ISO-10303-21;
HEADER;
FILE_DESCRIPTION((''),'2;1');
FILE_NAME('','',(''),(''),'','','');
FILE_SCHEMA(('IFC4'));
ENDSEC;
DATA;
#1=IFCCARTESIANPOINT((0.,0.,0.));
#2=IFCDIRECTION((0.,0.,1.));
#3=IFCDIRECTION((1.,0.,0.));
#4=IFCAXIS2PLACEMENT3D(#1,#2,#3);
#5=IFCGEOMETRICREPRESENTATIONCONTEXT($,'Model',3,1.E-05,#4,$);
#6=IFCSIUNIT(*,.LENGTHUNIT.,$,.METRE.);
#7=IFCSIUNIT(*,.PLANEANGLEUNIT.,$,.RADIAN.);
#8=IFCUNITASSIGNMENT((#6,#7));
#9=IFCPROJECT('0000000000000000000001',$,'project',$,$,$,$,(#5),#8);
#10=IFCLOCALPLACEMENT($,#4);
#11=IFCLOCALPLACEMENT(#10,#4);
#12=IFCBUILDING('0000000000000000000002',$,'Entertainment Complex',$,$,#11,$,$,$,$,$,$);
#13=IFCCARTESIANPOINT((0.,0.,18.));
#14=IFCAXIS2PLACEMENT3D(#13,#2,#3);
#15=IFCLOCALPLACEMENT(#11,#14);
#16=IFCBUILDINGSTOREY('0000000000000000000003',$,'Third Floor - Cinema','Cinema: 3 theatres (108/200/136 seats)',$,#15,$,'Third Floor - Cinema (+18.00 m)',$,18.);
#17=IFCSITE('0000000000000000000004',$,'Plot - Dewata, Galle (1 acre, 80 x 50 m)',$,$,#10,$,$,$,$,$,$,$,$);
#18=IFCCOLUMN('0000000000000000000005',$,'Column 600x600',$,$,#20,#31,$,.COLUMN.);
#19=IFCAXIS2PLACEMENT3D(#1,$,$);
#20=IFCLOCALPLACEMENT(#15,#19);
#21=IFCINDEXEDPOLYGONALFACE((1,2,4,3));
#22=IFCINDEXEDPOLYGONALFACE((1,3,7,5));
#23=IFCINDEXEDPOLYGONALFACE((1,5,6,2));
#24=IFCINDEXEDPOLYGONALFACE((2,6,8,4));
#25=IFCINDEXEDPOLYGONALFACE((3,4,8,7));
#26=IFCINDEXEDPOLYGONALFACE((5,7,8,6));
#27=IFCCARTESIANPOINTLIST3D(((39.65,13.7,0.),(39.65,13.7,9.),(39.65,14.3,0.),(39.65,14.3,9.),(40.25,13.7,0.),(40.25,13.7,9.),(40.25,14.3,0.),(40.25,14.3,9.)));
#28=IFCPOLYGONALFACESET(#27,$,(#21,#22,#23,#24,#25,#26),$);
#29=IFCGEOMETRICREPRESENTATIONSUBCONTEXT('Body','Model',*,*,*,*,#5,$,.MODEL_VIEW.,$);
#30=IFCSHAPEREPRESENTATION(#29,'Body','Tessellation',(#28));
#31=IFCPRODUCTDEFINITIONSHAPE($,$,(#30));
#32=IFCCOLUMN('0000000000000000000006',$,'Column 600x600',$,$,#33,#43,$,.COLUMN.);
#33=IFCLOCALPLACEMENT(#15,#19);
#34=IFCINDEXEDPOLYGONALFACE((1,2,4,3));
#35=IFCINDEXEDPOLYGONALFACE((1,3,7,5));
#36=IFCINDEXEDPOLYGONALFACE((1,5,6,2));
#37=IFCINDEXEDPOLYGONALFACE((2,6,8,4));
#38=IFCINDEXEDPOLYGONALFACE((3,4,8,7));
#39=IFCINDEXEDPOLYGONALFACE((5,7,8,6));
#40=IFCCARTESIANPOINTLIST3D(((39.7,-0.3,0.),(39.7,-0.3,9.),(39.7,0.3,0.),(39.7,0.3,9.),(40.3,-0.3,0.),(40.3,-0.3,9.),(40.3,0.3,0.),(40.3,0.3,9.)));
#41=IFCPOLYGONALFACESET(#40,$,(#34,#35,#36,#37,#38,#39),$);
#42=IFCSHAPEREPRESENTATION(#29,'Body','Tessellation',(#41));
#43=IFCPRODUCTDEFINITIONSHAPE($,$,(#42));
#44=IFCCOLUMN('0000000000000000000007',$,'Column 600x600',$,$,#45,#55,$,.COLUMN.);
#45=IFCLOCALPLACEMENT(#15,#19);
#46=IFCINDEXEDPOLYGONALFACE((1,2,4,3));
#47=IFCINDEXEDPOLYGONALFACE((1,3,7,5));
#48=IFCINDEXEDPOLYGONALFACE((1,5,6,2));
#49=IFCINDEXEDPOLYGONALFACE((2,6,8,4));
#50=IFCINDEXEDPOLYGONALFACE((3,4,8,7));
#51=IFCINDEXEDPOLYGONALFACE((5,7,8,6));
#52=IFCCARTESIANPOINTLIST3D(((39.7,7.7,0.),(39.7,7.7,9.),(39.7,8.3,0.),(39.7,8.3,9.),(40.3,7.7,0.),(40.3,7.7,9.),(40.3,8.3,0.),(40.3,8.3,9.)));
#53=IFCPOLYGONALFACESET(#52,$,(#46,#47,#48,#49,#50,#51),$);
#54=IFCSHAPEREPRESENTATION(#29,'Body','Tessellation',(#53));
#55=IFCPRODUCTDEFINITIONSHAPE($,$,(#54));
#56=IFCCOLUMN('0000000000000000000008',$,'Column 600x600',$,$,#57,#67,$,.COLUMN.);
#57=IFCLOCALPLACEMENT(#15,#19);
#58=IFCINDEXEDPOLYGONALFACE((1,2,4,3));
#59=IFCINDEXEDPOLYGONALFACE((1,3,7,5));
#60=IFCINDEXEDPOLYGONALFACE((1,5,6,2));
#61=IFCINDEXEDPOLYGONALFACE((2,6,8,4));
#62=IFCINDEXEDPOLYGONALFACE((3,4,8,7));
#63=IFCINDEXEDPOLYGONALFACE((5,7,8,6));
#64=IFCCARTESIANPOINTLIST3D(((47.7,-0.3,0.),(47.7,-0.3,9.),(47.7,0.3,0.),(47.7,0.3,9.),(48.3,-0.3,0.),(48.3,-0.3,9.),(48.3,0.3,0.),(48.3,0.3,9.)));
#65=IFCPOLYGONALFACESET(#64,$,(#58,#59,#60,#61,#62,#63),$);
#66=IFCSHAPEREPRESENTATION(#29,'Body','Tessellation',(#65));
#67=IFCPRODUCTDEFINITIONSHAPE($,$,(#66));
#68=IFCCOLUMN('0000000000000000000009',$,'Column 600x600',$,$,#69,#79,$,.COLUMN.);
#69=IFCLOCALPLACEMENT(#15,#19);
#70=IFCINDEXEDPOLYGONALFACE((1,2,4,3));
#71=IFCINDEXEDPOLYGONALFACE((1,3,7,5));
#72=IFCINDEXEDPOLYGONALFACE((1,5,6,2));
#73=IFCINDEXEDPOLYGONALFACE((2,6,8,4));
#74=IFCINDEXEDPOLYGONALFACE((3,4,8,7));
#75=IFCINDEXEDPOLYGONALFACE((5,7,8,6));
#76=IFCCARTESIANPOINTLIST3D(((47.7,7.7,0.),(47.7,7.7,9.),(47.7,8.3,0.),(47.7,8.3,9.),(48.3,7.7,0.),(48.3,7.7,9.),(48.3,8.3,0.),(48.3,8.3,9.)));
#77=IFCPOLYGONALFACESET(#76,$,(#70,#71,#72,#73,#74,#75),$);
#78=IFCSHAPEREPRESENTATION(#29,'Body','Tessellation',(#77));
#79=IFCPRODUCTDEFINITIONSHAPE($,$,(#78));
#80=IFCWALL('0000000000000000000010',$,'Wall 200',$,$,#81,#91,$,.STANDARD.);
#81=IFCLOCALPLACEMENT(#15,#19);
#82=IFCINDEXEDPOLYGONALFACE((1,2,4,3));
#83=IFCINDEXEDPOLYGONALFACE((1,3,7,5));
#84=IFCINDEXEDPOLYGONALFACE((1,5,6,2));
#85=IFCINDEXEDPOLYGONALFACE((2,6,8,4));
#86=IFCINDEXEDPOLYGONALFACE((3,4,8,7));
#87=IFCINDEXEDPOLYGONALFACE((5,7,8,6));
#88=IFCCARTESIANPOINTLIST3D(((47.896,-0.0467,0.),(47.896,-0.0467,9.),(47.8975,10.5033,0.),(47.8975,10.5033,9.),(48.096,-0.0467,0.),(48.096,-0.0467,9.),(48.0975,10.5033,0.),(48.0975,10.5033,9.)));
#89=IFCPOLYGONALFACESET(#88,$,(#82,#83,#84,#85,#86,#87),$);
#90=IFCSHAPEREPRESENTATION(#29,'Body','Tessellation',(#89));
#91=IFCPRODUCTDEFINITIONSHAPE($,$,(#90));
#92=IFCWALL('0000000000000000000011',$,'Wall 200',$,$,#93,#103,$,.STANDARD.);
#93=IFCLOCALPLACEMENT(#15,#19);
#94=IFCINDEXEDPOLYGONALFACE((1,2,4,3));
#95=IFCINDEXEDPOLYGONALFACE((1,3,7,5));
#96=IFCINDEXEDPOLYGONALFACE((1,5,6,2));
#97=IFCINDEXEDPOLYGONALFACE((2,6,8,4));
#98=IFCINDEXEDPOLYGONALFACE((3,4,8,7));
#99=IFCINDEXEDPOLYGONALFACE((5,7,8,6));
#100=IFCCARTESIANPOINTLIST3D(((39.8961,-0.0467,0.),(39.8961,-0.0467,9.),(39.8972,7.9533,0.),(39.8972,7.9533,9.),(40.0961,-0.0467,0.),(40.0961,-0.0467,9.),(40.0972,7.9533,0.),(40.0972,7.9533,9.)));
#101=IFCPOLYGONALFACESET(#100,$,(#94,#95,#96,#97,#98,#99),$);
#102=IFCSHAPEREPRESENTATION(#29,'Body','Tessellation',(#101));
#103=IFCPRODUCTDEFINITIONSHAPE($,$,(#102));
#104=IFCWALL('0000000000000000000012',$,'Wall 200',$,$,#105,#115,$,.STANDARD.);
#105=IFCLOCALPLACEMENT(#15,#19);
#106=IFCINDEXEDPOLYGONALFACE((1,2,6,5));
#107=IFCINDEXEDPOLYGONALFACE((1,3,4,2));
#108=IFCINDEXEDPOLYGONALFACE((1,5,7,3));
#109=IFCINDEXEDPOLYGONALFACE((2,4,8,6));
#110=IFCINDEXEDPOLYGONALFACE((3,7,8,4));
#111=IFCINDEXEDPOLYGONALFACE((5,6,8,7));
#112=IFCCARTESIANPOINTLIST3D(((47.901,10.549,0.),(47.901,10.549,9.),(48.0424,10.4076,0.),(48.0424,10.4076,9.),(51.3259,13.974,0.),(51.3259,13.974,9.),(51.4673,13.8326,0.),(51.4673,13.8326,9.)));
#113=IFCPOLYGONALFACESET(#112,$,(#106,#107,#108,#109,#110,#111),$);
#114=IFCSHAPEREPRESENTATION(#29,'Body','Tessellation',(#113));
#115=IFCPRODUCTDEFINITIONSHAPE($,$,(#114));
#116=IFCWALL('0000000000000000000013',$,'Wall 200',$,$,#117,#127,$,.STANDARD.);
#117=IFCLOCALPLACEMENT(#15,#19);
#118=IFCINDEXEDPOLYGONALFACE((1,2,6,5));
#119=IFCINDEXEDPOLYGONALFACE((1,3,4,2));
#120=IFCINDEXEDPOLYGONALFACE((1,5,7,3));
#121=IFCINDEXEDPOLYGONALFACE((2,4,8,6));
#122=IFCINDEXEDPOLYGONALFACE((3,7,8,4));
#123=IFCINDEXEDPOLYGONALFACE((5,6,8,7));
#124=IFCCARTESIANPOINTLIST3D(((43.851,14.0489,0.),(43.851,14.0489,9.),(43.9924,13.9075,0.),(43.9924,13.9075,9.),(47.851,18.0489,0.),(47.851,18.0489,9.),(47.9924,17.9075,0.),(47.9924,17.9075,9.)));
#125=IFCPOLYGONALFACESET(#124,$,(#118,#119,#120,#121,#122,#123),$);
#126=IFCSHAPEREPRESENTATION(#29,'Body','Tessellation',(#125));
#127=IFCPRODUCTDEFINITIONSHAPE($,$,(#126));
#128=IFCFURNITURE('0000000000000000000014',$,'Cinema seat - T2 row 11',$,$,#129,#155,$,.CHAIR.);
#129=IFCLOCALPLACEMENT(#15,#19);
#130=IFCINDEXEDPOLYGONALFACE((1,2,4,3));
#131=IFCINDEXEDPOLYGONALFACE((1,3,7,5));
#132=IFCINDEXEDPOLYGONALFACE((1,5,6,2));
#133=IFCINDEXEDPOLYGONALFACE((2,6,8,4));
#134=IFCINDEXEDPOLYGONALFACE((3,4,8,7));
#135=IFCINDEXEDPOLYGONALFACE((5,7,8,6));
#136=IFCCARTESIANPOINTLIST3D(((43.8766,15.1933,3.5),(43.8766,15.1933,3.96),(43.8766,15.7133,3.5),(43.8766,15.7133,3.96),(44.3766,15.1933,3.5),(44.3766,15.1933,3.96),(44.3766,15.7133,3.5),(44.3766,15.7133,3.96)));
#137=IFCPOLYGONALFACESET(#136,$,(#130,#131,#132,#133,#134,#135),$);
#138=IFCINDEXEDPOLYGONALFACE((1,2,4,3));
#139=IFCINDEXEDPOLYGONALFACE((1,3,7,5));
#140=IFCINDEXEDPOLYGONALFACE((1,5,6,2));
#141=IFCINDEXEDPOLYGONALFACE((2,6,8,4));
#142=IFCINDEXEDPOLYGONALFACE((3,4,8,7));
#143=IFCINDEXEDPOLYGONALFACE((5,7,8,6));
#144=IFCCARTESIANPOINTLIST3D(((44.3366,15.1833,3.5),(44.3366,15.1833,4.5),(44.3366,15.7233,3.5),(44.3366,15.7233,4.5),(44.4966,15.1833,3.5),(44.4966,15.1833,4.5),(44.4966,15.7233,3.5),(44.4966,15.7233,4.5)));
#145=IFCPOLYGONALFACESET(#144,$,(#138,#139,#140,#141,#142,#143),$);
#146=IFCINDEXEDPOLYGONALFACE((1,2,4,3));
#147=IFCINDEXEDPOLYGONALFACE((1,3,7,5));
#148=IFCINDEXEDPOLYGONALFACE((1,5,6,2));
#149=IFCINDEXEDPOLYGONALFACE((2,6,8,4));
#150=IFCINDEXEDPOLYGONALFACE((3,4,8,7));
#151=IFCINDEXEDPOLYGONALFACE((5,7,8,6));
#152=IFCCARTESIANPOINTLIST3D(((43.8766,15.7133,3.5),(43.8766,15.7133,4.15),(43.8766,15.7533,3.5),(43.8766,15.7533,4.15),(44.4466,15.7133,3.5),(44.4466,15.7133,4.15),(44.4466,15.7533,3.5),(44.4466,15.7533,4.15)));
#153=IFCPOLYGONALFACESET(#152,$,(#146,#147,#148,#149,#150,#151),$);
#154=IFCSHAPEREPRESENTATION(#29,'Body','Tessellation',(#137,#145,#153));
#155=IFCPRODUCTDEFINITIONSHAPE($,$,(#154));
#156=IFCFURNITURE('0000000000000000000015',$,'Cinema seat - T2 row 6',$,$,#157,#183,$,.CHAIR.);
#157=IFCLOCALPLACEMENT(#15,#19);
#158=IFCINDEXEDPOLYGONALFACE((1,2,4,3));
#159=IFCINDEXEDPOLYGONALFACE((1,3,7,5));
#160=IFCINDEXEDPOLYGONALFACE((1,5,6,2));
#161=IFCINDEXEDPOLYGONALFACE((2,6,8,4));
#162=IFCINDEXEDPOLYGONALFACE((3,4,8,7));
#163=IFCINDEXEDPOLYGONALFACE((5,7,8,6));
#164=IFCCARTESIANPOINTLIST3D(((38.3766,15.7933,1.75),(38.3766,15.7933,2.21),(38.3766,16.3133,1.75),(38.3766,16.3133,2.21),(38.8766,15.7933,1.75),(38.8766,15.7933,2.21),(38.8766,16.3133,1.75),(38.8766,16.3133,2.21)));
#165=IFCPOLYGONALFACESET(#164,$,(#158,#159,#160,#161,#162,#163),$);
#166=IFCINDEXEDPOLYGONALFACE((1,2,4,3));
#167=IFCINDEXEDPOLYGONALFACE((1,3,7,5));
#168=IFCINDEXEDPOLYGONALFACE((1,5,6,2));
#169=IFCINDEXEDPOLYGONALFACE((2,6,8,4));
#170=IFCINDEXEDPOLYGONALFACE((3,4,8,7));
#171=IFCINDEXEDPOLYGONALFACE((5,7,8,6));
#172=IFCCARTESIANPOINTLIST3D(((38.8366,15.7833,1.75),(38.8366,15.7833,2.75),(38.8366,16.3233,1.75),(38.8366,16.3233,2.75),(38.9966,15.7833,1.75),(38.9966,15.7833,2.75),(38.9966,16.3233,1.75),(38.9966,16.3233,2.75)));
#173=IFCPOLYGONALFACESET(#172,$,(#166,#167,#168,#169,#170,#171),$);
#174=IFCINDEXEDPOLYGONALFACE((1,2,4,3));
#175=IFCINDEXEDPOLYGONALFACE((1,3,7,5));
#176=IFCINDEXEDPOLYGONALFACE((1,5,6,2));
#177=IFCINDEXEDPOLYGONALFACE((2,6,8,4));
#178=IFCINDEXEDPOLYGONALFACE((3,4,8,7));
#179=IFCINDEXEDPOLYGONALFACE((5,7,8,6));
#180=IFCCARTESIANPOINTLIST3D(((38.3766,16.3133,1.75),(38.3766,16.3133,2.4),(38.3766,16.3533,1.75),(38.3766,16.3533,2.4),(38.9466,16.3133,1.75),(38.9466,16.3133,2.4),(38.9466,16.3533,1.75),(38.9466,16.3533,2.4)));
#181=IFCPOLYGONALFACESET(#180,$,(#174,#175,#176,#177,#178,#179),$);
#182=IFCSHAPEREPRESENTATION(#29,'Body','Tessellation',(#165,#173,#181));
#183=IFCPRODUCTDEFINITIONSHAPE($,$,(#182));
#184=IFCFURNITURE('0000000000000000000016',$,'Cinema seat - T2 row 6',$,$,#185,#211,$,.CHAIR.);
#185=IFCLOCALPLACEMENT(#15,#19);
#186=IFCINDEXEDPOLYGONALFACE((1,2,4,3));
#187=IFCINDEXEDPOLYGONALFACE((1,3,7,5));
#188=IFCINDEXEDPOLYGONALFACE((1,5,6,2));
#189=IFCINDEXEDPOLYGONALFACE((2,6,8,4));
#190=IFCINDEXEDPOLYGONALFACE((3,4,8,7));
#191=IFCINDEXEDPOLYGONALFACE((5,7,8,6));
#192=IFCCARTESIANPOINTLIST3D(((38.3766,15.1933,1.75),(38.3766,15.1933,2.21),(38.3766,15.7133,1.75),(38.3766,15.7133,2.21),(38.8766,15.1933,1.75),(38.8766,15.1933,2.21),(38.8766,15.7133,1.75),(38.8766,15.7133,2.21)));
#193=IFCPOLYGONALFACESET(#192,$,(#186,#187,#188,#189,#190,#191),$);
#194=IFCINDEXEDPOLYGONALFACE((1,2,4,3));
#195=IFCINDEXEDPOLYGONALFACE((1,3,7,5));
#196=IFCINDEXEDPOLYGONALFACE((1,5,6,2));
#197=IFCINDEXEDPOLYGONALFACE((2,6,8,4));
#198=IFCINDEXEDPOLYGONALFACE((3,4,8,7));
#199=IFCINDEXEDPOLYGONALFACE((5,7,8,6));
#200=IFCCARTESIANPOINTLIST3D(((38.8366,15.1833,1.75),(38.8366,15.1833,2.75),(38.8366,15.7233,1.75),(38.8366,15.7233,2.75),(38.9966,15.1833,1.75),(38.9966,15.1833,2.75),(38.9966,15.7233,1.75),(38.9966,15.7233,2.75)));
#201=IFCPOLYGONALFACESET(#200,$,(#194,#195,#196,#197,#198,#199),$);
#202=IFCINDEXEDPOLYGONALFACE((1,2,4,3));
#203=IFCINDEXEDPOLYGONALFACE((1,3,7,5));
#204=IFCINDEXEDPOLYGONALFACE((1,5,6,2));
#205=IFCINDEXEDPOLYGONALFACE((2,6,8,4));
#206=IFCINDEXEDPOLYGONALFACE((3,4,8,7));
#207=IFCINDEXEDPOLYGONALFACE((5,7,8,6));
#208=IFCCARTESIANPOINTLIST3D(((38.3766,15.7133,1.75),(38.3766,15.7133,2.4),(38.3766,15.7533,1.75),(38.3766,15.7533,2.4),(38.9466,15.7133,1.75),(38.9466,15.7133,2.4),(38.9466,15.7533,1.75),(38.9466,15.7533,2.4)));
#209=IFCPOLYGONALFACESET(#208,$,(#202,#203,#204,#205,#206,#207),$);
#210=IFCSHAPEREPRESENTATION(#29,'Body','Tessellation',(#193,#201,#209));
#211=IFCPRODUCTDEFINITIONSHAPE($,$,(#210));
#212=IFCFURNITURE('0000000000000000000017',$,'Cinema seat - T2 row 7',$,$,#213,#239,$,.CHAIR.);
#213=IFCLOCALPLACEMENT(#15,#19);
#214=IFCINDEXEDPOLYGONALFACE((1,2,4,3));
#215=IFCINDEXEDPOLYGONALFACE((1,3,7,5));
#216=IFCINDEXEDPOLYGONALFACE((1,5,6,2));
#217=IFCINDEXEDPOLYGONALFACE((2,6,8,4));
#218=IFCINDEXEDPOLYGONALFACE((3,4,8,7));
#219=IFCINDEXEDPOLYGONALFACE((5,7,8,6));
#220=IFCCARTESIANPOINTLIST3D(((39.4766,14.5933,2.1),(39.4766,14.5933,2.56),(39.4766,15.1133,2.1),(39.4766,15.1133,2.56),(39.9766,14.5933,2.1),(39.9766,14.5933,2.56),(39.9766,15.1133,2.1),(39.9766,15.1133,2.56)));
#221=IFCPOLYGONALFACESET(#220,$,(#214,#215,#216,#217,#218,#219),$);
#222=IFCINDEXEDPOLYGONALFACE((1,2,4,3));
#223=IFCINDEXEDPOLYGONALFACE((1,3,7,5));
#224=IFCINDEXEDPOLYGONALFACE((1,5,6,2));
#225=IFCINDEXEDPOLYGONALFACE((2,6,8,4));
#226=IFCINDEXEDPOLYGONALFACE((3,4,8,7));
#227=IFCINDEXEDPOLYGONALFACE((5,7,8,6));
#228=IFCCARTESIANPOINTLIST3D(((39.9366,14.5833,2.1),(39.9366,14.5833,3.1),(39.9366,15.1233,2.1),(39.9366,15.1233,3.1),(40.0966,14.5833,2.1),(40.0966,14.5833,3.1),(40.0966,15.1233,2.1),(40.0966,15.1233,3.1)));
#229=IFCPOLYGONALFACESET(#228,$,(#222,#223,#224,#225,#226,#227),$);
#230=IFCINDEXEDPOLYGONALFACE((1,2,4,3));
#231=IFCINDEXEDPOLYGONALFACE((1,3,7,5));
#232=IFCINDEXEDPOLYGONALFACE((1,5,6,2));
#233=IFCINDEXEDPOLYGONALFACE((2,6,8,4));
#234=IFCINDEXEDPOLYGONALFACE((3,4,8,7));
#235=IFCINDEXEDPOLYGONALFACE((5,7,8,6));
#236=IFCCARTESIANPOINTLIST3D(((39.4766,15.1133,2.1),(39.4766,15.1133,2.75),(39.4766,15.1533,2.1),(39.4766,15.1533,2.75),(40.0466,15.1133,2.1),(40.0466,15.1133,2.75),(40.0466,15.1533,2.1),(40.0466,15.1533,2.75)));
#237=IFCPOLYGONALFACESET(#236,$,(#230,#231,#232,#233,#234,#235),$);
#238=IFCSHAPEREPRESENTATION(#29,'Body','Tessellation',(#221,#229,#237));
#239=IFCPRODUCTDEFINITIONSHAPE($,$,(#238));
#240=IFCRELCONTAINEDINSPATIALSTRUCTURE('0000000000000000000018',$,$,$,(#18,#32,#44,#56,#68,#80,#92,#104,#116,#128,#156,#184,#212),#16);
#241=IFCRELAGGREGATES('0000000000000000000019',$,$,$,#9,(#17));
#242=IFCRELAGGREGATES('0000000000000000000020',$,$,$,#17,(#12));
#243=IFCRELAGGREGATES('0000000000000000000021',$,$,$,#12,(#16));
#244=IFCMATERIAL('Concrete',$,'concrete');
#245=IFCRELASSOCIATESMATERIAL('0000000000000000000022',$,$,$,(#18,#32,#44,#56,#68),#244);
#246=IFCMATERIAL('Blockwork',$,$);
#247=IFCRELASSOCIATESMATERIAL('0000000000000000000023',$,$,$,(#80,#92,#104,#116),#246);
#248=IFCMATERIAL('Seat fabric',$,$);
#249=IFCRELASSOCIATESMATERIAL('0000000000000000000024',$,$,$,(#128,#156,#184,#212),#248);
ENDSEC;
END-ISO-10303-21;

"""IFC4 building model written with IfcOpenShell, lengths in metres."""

from ifc_helpers import new_model, si_unit, frame, origin_with_axes, place, context, subcontext, project, spatial, polyline, outline, extrude, material, element, save


model = new_model("IFC4")

# Units and contexts
model_context = context("Model", 3, precision=1e-05, world=origin_with_axes())
body_context = subcontext(model_context, "Body", "Model", "MODEL_VIEW")
ifc_project = project(units=[si_unit("LENGTHUNIT", "METRE"), si_unit("PLANEANGLEUNIT", "RADIAN")], contexts=[model_context])

# Site, building, storey
site_placement = place(None, origin_with_axes())
site = spatial("IfcSite", under=ifc_project, at=site_placement, Name="Plot - Dewata, Galle (1 acre, 80 x 50 m)")
building_placement = place(site_placement, origin_with_axes())
building = spatial("IfcBuilding", under=site, at=building_placement, Name="Entertainment Complex")
storey_placement = place(building_placement, frame((0.0, 0.0, 18.0), z_axis=(0.0, 0.0, 1.0), x_axis=(1.0, 0.0, 0.0)))
storey = spatial("IfcBuildingStorey", under=building, at=storey_placement, Name="Third Floor - Cinema", Description="Cinema: 3 theatres (108/200/136 seats)", LongName="Third Floor - Cinema (+18.00 m)", Elevation=18.0)

# Columns
ifc_material_1 = material(Name="Concrete", Category="concrete")
for number, where, z_axis, x_axis, name in (
    (1, (39.95, 14.0, 0.0), (0.0, 0.0, 1.0), (1.0, 0.0, 0.0), "Column 600x600"),
    (2, (40.0, 0.0, 0.0), (0.0, 0.0, 1.0), (1.0, 0.0, 0.0), "Column 600x600"),
    (3, (40.0, 8.0, 0.0), (0.0, 0.0, 1.0), (1.0, 0.0, 0.0), "Column 600x600"),
    (4, (48.0, 0.0, 0.0), (0.0, 0.0, 1.0), (1.0, 0.0, 0.0), "Column 600x600"),
    (5, (48.0, 8.0, 0.0), (0.0, 0.0, 1.0), (1.0, 0.0, 0.0), "Column 600x600"),
):
    element("IfcColumn", number, at=place(storey_placement, frame(where, z_axis=z_axis, x_axis=x_axis)), inside=storey, material=ifc_material_1, Name=name, PredefinedType="COLUMN", context=body_context, shape_type="SweptSolid", body=[
        extrude(outline(polyline([(-0.3, -0.3), (0.3, -0.3), (0.3, 0.3), (-0.3, 0.3), (-0.3, -0.3)])), origin_with_axes(), (0.0, 0.0, 1.0), 9.0),
    ])

# Walls
ifc_material_2 = material(Name="Blockwork")
wall_1_placement = place(storey_placement, frame((47.996, -0.0467, 0.0), z_axis=(0.0, 0.0, 1.0), x_axis=(0.000142, 1.0, 0.0)))
element("IfcWall", 6, at=wall_1_placement, inside=storey, material=ifc_material_2, Name="Wall 200", PredefinedType="STANDARD", context=body_context, shape_type="SweptSolid", body=[
    extrude(outline(polyline([(0.0, -0.1), (10.55, -0.1), (10.55, 0.1), (0.0, 0.1), (0.0, -0.1)])), origin_with_axes(), (0.0, 0.0, 1.0), 9.0),
])
wall_2_placement = place(storey_placement, frame((39.9961, -0.0467, 0.0), z_axis=(0.0, 0.0, 1.0), x_axis=(0.000137, 1.0, 0.0)))
element("IfcWall", 7, at=wall_2_placement, inside=storey, material=ifc_material_2, Name="Wall 200", PredefinedType="STANDARD", context=body_context, shape_type="SweptSolid", body=[
    extrude(outline(polyline([(0.0, -0.1), (8.0, -0.1), (8.0, 0.1), (0.0, 0.1), (0.0, -0.1)])), origin_with_axes(), (0.0, 0.0, 1.0), 9.0),
])
wall_3_placement = place(storey_placement, frame((47.9717, 10.4783, 0.0), z_axis=(0.0, 0.0, 1.0), x_axis=(0.707096, 0.707117, 0.0)))
element("IfcWall", 8, at=wall_3_placement, inside=storey, material=ifc_material_2, Name="Wall 200", PredefinedType="STANDARD", context=body_context, shape_type="SweptSolid", body=[
    extrude(outline(polyline([(0.0, -0.1), (4.8436, -0.1), (4.8436, 0.1), (0.0, 0.1), (0.0, -0.1)])), origin_with_axes(), (0.0, 0.0, 1.0), 9.0),
])
wall_4_placement = place(storey_placement, frame((43.9217, 13.9782, 0.0), z_axis=(0.0, 0.0, 1.0), x_axis=(0.707107, 0.707107, 0.0)))
element("IfcWall", 9, at=wall_4_placement, inside=storey, material=ifc_material_2, Name="Wall 200", PredefinedType="STANDARD", context=body_context, shape_type="SweptSolid", body=[
    extrude(outline(polyline([(0.0, -0.1), (5.6569, -0.1), (5.6569, 0.1), (0.0, 0.1), (0.0, -0.1)])), origin_with_axes(), (0.0, 0.0, 1.0), 9.0),
])

# Furniture
ifc_material_3 = material(Name="Seat fabric")
for number, where, z_axis, x_axis, name in (
    (10, (44.4966, 15.4533, 3.5), (0.0, 0.0, 1.0), (1.0, 0.0, 0.0), "Cinema seat - T2 row 11"),
    (11, (38.9966, 16.0533, 1.75), (0.0, 0.0, 1.0), (1.0, 0.0, 0.0), "Cinema seat - T2 row 6"),
    (12, (38.9966, 15.4533, 1.75), (0.0, 0.0, 1.0), (1.0, 0.0, 0.0), "Cinema seat - T2 row 6"),
    (13, (40.0966, 14.8533, 2.1), (0.0, 0.0, 1.0), (1.0, 0.0, 0.0), "Cinema seat - T2 row 7"),
):
    element("IfcFurniture", number, at=place(storey_placement, frame(where, z_axis=z_axis, x_axis=x_axis)), inside=storey, material=ifc_material_3, Name=name, PredefinedType="CHAIR", context=body_context, shape_type="SweptSolid", body=[
        extrude(outline(polyline([(-0.62, -0.26), (-0.12, -0.26), (-0.12, 0.26), (-0.62, 0.26), (-0.62, -0.26)])), origin_with_axes(), (0.0, 0.0, 1.0), 0.46),
        extrude(outline(polyline([(-0.16, -0.27), (0.0, -0.27), (0.0, 0.27), (-0.16, 0.27), (-0.16, -0.27)])), origin_with_axes(), (0.0, 0.0, 1.0), 1.0),
        extrude(outline(polyline([(-0.62, 0.26), (-0.05, 0.26), (-0.05, 0.3), (-0.62, 0.3), (-0.62, 0.26)])), origin_with_axes(), (0.0, 0.0, 1.0), 0.65),
    ])

save(model, "model.ifc")
